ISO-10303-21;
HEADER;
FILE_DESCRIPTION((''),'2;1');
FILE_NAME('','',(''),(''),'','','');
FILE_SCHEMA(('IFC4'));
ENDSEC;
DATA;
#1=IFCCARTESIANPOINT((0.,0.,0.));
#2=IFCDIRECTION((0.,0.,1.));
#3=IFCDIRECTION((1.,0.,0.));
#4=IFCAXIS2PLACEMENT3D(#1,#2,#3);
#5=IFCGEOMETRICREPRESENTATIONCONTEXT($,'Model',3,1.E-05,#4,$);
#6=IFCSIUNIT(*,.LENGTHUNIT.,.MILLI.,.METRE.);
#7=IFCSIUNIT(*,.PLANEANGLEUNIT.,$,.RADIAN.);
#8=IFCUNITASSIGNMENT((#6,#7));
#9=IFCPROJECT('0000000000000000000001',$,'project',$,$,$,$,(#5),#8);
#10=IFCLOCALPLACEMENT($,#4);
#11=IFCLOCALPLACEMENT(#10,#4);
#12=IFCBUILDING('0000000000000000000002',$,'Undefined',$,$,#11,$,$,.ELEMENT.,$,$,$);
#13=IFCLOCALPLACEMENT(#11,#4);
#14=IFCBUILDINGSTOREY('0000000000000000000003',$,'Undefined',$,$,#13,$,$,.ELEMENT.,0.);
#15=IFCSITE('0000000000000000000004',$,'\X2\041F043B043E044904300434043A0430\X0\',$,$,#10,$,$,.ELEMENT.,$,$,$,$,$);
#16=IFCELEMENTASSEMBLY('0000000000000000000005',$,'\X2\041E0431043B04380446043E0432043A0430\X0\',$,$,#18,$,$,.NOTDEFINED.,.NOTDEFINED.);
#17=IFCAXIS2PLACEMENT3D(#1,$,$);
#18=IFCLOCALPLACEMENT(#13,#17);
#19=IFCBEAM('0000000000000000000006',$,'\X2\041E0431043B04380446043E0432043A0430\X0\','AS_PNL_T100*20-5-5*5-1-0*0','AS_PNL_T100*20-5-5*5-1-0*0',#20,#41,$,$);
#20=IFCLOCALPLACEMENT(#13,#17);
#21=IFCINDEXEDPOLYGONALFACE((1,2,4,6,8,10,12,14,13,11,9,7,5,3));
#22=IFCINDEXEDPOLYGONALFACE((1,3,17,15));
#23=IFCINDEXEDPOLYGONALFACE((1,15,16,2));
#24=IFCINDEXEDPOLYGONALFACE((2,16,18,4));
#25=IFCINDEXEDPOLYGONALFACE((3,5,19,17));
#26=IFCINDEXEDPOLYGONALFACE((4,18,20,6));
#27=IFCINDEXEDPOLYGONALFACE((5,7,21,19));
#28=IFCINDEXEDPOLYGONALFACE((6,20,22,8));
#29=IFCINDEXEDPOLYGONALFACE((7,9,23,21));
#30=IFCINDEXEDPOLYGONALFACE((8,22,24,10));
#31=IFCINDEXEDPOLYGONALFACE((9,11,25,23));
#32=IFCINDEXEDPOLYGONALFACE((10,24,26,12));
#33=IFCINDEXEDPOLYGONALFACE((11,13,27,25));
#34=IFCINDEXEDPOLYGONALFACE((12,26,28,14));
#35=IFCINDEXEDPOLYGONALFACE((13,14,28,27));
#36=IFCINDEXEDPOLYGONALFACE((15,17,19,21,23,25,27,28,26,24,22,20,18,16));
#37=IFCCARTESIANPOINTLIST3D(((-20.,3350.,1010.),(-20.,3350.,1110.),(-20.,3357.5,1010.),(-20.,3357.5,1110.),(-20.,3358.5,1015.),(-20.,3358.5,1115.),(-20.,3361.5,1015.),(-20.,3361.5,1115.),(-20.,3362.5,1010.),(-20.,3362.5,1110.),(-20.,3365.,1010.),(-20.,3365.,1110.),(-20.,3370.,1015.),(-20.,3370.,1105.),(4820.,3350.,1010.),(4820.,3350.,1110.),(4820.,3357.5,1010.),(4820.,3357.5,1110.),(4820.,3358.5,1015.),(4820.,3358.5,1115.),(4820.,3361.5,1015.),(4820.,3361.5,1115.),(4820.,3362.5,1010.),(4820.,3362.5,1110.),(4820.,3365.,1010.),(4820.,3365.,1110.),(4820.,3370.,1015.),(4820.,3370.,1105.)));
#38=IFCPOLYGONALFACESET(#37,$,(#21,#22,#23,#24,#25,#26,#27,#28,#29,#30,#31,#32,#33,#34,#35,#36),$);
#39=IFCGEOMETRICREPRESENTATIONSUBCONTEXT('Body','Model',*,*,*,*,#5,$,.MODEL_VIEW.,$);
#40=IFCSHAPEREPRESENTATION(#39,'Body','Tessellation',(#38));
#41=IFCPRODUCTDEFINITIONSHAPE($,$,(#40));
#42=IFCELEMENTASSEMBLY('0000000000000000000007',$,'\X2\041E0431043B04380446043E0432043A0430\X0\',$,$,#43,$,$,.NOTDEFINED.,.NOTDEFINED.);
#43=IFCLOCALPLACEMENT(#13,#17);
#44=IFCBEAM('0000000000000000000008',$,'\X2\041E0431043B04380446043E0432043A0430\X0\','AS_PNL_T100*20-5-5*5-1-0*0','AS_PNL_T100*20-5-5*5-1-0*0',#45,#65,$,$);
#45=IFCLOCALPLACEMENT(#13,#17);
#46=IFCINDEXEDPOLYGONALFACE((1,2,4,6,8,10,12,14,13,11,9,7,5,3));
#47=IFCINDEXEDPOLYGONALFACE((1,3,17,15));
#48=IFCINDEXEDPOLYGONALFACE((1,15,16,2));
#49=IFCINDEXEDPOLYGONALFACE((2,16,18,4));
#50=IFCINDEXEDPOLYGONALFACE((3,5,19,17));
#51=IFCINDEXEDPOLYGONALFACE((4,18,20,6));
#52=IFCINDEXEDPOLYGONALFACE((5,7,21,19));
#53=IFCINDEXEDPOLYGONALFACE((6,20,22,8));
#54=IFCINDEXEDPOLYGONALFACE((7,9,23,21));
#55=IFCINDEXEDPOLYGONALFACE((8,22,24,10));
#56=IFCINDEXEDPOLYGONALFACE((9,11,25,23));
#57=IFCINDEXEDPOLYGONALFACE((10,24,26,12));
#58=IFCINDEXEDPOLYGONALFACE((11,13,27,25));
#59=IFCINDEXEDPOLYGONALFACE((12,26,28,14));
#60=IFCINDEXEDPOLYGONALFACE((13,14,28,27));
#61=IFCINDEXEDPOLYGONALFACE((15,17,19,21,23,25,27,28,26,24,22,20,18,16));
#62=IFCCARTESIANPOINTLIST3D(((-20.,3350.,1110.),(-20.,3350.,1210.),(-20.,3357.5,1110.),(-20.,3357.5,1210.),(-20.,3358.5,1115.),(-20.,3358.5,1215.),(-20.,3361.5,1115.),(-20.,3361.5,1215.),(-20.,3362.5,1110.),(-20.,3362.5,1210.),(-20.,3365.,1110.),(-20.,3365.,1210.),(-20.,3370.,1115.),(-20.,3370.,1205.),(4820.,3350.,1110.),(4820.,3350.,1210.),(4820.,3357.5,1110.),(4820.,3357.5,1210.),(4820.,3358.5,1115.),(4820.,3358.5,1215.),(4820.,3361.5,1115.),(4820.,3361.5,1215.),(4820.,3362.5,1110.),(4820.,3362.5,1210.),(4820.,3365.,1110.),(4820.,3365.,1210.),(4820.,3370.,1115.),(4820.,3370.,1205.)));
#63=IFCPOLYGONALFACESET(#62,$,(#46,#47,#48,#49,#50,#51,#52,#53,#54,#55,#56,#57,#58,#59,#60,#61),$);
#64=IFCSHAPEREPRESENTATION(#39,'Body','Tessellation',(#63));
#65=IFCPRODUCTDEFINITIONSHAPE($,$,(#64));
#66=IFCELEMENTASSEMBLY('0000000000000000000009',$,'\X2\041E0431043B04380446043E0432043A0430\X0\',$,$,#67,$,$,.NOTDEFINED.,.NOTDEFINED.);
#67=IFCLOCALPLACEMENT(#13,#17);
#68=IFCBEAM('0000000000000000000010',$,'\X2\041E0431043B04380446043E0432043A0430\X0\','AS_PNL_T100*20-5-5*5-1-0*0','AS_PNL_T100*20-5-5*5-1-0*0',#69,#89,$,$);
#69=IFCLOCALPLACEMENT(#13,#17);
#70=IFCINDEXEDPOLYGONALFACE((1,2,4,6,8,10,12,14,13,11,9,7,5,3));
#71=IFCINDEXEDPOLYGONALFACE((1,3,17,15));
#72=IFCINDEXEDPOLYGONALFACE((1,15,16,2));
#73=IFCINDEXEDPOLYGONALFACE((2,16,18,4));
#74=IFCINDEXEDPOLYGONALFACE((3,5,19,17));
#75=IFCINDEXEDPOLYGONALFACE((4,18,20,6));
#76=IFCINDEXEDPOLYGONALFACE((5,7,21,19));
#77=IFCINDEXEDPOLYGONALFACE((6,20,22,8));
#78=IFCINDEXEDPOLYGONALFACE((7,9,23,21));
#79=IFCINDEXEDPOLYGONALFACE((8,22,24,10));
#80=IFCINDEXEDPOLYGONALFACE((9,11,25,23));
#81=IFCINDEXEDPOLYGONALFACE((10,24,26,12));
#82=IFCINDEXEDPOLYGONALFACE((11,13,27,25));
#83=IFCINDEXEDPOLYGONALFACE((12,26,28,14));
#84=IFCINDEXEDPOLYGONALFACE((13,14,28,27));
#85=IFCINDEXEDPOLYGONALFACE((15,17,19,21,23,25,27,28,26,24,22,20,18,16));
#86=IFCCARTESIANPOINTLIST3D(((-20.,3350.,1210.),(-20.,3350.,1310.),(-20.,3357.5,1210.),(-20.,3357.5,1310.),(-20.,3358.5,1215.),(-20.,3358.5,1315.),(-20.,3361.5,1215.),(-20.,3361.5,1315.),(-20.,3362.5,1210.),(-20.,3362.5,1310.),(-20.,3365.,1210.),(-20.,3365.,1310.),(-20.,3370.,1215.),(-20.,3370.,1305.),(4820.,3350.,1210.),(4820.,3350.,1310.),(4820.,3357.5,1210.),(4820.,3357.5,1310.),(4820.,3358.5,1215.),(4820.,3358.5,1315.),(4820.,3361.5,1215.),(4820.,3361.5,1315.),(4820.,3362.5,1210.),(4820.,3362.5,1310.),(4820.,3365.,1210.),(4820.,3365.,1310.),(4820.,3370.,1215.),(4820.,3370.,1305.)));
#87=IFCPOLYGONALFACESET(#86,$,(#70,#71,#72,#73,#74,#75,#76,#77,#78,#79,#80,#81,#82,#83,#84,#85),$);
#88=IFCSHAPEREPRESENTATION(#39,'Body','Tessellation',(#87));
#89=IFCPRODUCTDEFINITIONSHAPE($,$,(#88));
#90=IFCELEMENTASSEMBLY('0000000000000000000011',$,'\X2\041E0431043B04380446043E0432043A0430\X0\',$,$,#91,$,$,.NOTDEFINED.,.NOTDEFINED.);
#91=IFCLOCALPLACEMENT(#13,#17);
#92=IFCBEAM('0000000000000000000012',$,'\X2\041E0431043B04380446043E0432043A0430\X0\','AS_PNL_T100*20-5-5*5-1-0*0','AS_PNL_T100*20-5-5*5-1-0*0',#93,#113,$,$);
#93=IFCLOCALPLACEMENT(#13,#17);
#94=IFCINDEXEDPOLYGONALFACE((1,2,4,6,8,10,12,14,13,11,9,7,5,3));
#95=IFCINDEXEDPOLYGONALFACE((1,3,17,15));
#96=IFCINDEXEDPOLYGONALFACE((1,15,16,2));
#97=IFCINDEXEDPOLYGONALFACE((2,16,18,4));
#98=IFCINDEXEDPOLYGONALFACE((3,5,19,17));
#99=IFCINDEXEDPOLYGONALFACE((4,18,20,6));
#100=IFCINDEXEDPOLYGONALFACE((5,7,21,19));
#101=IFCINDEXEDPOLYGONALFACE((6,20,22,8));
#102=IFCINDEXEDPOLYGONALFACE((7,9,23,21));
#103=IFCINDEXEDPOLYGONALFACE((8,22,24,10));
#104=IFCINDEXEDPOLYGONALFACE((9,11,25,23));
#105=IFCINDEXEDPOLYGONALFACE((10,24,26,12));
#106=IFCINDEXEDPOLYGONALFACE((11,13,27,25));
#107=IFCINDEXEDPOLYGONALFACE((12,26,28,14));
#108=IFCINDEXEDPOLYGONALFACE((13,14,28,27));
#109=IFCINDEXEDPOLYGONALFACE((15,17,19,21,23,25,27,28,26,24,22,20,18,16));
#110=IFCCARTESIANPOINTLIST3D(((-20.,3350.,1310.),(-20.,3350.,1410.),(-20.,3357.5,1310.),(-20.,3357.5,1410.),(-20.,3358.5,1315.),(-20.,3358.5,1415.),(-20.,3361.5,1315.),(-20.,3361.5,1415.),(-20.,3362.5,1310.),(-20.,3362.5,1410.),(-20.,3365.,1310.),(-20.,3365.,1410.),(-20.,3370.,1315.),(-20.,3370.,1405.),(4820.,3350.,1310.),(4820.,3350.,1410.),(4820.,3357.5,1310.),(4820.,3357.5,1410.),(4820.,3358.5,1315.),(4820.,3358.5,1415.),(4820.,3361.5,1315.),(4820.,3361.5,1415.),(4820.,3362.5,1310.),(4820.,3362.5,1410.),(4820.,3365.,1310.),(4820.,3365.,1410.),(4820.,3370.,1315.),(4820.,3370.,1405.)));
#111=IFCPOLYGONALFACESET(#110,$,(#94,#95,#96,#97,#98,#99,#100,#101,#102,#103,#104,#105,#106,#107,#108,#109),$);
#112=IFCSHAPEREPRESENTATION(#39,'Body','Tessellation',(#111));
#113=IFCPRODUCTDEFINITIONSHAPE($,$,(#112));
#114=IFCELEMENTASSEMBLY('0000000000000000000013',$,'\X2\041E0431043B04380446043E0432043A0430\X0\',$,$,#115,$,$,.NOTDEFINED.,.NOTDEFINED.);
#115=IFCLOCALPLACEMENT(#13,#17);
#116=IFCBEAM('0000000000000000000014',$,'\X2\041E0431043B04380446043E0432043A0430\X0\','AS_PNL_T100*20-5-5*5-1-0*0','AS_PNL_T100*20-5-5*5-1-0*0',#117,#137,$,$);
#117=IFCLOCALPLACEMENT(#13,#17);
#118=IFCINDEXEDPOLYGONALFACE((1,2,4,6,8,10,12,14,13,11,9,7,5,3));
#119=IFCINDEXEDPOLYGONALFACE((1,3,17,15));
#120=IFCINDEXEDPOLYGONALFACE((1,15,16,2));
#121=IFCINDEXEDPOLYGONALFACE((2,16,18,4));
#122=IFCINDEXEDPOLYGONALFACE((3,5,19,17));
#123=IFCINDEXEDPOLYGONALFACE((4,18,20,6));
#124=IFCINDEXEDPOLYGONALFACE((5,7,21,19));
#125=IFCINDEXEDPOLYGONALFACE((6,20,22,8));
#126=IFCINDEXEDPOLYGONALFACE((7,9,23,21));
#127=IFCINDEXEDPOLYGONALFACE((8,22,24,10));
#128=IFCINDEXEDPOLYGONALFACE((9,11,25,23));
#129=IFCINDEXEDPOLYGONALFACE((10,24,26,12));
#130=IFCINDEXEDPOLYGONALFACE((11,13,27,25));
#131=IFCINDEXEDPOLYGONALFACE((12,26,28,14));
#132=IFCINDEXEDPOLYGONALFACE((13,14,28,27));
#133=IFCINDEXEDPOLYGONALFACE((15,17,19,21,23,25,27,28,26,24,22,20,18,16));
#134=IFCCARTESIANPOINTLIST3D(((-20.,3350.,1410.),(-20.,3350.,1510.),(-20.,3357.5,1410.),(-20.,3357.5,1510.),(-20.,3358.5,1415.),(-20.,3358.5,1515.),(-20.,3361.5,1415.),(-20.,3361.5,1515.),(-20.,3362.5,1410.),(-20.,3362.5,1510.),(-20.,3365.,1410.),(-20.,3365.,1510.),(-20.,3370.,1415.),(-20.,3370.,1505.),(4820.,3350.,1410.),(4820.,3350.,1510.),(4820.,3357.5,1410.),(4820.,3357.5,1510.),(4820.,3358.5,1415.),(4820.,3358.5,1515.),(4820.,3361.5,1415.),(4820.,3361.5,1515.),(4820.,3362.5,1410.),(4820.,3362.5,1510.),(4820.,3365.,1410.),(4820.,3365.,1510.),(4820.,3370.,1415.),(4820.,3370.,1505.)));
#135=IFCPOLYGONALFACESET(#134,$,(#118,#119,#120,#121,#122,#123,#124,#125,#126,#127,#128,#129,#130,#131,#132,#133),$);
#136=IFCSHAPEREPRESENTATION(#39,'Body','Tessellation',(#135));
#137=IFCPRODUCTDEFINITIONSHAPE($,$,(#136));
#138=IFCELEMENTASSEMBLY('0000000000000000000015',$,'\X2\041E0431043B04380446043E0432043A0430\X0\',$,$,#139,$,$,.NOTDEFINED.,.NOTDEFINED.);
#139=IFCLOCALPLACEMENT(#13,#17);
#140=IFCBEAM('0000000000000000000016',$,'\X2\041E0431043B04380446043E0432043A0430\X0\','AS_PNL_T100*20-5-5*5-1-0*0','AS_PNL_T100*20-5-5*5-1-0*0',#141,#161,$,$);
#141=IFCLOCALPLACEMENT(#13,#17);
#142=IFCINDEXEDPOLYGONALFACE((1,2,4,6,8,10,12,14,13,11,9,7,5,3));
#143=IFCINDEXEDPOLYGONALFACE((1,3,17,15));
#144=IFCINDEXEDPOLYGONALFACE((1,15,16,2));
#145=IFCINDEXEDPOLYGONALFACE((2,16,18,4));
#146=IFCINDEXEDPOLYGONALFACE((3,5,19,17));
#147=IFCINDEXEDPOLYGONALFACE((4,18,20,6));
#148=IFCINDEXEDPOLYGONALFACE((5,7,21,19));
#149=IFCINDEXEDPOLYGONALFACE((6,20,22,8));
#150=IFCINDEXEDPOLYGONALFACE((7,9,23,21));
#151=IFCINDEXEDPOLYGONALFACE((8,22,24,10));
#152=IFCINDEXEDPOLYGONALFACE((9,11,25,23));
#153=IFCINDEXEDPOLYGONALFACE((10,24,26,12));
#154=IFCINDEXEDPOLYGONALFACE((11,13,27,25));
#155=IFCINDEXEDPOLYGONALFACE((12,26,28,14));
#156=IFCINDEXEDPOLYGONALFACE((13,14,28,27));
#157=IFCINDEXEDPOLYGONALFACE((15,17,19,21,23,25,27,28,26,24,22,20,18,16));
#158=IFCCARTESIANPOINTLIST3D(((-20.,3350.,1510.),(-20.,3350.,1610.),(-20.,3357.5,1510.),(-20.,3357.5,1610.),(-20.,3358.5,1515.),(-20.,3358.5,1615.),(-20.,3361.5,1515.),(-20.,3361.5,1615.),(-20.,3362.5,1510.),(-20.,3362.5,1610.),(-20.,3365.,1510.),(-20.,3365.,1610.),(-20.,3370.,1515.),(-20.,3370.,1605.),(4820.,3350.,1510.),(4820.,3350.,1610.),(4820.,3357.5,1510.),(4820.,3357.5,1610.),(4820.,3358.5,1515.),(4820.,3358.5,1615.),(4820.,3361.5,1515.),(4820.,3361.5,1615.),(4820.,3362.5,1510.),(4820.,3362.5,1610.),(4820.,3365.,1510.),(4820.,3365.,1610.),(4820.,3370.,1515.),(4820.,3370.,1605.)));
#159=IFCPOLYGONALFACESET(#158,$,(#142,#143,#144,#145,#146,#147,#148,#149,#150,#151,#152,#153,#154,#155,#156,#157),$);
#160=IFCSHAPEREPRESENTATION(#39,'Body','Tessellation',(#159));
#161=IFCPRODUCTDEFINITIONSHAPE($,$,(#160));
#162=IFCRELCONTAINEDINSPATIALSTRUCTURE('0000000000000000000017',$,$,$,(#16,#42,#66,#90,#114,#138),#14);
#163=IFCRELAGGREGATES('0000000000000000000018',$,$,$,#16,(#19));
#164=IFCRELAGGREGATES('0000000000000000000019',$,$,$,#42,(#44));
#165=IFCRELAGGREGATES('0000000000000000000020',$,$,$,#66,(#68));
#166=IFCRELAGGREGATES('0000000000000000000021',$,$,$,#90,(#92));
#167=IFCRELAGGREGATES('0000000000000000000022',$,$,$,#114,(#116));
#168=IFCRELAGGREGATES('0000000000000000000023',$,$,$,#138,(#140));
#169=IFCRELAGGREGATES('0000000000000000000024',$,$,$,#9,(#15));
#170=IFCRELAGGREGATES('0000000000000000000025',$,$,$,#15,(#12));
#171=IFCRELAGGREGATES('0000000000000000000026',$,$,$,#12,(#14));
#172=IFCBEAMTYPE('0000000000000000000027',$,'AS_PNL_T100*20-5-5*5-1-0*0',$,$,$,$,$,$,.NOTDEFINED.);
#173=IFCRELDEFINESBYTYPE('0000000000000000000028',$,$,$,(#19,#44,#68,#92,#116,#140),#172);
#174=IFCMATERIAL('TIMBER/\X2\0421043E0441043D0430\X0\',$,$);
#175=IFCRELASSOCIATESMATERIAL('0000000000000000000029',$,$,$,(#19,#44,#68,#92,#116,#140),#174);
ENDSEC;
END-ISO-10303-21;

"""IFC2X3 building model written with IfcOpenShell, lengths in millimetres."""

from ifc_helpers import new_model, si_unit, frame, origin_with_axes, place, context, subcontext, project, spatial, polyline, outline, extrude, material, type_object, element, aggregate, save


model = new_model("IFC2X3")

# Units and contexts
model_context = context("Model", 3, precision=1e-05, world=origin_with_axes())
body_context = subcontext(model_context, "Body", "Model", "MODEL_VIEW")
ifc_project = project(units=[si_unit("LENGTHUNIT", "METRE", prefix="MILLI"), si_unit("PLANEANGLEUNIT", "RADIAN")], contexts=[model_context])

# Site, building, storey
site_placement = place(None, origin_with_axes())
site = spatial("IfcSite", under=ifc_project, at=site_placement, Name="Площадка", CompositionType="ELEMENT")
building_placement = place(site_placement, origin_with_axes())
building = spatial("IfcBuilding", under=site, at=building_placement, Name="Undefined", CompositionType="ELEMENT")
storey_placement = place(building_placement, origin_with_axes())
storey = spatial("IfcBuildingStorey", under=building, at=storey_placement, Name="Undefined", CompositionType="ELEMENT", Elevation=0.0)

# Shared definitions
ifc_material = material(Name="TIMBER/Сосна")

# Element assemblies, beams
assembly_1_placement = place(storey_placement, origin_with_axes())
assembly_1 = element("IfcElementAssembly", 1, at=assembly_1_placement, inside=storey, Name="Облицовка", AssemblyPlace="NOTDEFINED", PredefinedType="NOTDEFINED")
beam_type_1 = type_object("IfcBeamType", Name="AS_PNL_T100*20-5-5*5-1-0*0", PredefinedType="NOTDEFINED")
beam_1_placement = place(assembly_1_placement, frame((4820.0, 3360.0, 1060.0), z_axis=(0.0, 0.0, 1.0), x_axis=(-1.0, 0.0, 0.0)))
beam_1 = element("IfcBeam", 2, at=beam_1_placement, type_object=beam_type_1, material=ifc_material, Name="Облицовка", Description="AS_PNL_T100*20-5-5*5-1-0*0", ObjectType="AS_PNL_T100*20-5-5*5-1-0*0", context=body_context, shape_type="SweptSolid", body=[
    extrude(outline(polyline([(-2.5, -50.0), (-10.0, -50.0), (-10.0, 50.0), (-2.5, 50.0), (-1.5, 55.0), (1.5, 55.0), (2.5, 50.0), (5.0, 50.0), (10.0, 45.0), (10.0, -45.0), (5.0, -50.0), (2.5, -50.0), (1.5, -45.0), (-1.5, -45.0), (-2.5, -50.0)])), frame((4840.0, 0.0, 0.0), z_axis=(-1.0, 0.0, 0.0), x_axis=(0.0, -1.0, 0.0)), (0.0, 0.0, 1.0), 4840.0),
])
aggregate(assembly_1, [beam_1])
assembly_2_placement = place(storey_placement, origin_with_axes())
assembly_2 = element("IfcElementAssembly", 3, at=assembly_2_placement, inside=storey, Name="Облицовка", AssemblyPlace="NOTDEFINED", PredefinedType="NOTDEFINED")
beam_2_placement = place(assembly_2_placement, frame((4820.0, 3360.0, 1160.0), z_axis=(0.0, 0.0, 1.0), x_axis=(-1.0, 0.0, 0.0)))
beam_2 = element("IfcBeam", 4, at=beam_2_placement, type_object=beam_type_1, material=ifc_material, Name="Облицовка", Description="AS_PNL_T100*20-5-5*5-1-0*0", ObjectType="AS_PNL_T100*20-5-5*5-1-0*0", context=body_context, shape_type="SweptSolid", body=[
    extrude(outline(polyline([(-2.5, -50.0), (-10.0, -50.0), (-10.0, 50.0), (-2.5, 50.0), (-1.5, 55.0), (1.5, 55.0), (2.5, 50.0), (5.0, 50.0), (10.0, 45.0), (10.0, -45.0), (5.0, -50.0), (2.5, -50.0), (1.5, -45.0), (-1.5, -45.0), (-2.5, -50.0)])), frame((4840.0, 0.0, 0.0), z_axis=(-1.0, 0.0, 0.0), x_axis=(0.0, -1.0, 0.0)), (0.0, 0.0, 1.0), 4840.0),
])
aggregate(assembly_2, [beam_2])
assembly_3_placement = place(storey_placement, origin_with_axes())
assembly_3 = element("IfcElementAssembly", 5, at=assembly_3_placement, inside=storey, Name="Облицовка", AssemblyPlace="NOTDEFINED", PredefinedType="NOTDEFINED")
beam_3_placement = place(assembly_3_placement, frame((4820.0, 3360.0, 1260.0), z_axis=(0.0, 0.0, 1.0), x_axis=(-1.0, 0.0, 0.0)))
beam_3 = element("IfcBeam", 6, at=beam_3_placement, type_object=beam_type_1, material=ifc_material, Name="Облицовка", Description="AS_PNL_T100*20-5-5*5-1-0*0", ObjectType="AS_PNL_T100*20-5-5*5-1-0*0", context=body_context, shape_type="SweptSolid", body=[
    extrude(outline(polyline([(-2.5, -50.0), (-10.0, -50.0), (-10.0, 50.0), (-2.5, 50.0), (-1.5, 55.0), (1.5, 55.0), (2.5, 50.0), (5.0, 50.0), (10.0, 45.0), (10.0, -45.0), (5.0, -50.0), (2.5, -50.0), (1.5, -45.0), (-1.5, -45.0), (-2.5, -50.0)])), frame((4840.0, 0.0, 0.0), z_axis=(-1.0, 0.0, 0.0), x_axis=(0.0, -1.0, 0.0)), (0.0, 0.0, 1.0), 4840.0),
])
aggregate(assembly_3, [beam_3])
assembly_4_placement = place(storey_placement, origin_with_axes())
assembly_4 = element("IfcElementAssembly", 7, at=assembly_4_placement, inside=storey, Name="Облицовка", AssemblyPlace="NOTDEFINED", PredefinedType="NOTDEFINED")
beam_4_placement = place(assembly_4_placement, frame((4820.0, 3360.0, 1360.0), z_axis=(0.0, 0.0, 1.0), x_axis=(-1.0, 0.0, 0.0)))
beam_4 = element("IfcBeam", 8, at=beam_4_placement, type_object=beam_type_1, material=ifc_material, Name="Облицовка", Description="AS_PNL_T100*20-5-5*5-1-0*0", ObjectType="AS_PNL_T100*20-5-5*5-1-0*0", context=body_context, shape_type="SweptSolid", body=[
    extrude(outline(polyline([(-2.5, -50.0), (-10.0, -50.0), (-10.0, 50.0), (-2.5, 50.0), (-1.5, 55.0), (1.5, 55.0), (2.5, 50.0), (5.0, 50.0), (10.0, 45.0), (10.0, -45.0), (5.0, -50.0), (2.5, -50.0), (1.5, -45.0), (-1.5, -45.0), (-2.5, -50.0)])), frame((4840.0, 0.0, 0.0), z_axis=(-1.0, 0.0, 0.0), x_axis=(0.0, -1.0, 0.0)), (0.0, 0.0, 1.0), 4840.0),
])
aggregate(assembly_4, [beam_4])
assembly_5_placement = place(storey_placement, origin_with_axes())
assembly_5 = element("IfcElementAssembly", 9, at=assembly_5_placement, inside=storey, Name="Облицовка", AssemblyPlace="NOTDEFINED", PredefinedType="NOTDEFINED")
beam_5_placement = place(assembly_5_placement, frame((4820.0, 3360.0, 1460.0), z_axis=(0.0, 0.0, 1.0), x_axis=(-1.0, 0.0, 0.0)))
beam_5 = element("IfcBeam", 10, at=beam_5_placement, type_object=beam_type_1, material=ifc_material, Name="Облицовка", Description="AS_PNL_T100*20-5-5*5-1-0*0", ObjectType="AS_PNL_T100*20-5-5*5-1-0*0", context=body_context, shape_type="SweptSolid", body=[
    extrude(outline(polyline([(-2.5, -50.0), (-10.0, -50.0), (-10.0, 50.0), (-2.5, 50.0), (-1.5, 55.0), (1.5, 55.0), (2.5, 50.0), (5.0, 50.0), (10.0, 45.0), (10.0, -45.0), (5.0, -50.0), (2.5, -50.0), (1.5, -45.0), (-1.5, -45.0), (-2.5, -50.0)])), frame((4840.0, 0.0, 0.0), z_axis=(-1.0, 0.0, 0.0), x_axis=(0.0, -1.0, 0.0)), (0.0, 0.0, 1.0), 4840.0),
])
aggregate(assembly_5, [beam_5])
assembly_6_placement = place(storey_placement, origin_with_axes())
assembly_6 = element("IfcElementAssembly", 11, at=assembly_6_placement, inside=storey, Name="Облицовка", AssemblyPlace="NOTDEFINED", PredefinedType="NOTDEFINED")
beam_6_placement = place(assembly_6_placement, frame((4820.0, 3360.0, 1560.0), z_axis=(0.0, 0.0, 1.0), x_axis=(-1.0, 0.0, 0.0)))
beam_6 = element("IfcBeam", 12, at=beam_6_placement, type_object=beam_type_1, material=ifc_material, Name="Облицовка", Description="AS_PNL_T100*20-5-5*5-1-0*0", ObjectType="AS_PNL_T100*20-5-5*5-1-0*0", context=body_context, shape_type="SweptSolid", body=[
    extrude(outline(polyline([(-2.5, -50.0), (-10.0, -50.0), (-10.0, 50.0), (-2.5, 50.0), (-1.5, 55.0), (1.5, 55.0), (2.5, 50.0), (5.0, 50.0), (10.0, 45.0), (10.0, -45.0), (5.0, -50.0), (2.5, -50.0), (1.5, -45.0), (-1.5, -45.0), (-2.5, -50.0)])), frame((4840.0, 0.0, 0.0), z_axis=(-1.0, 0.0, 0.0), x_axis=(0.0, -1.0, 0.0)), (0.0, 0.0, 1.0), 4840.0),
])
aggregate(assembly_6, [beam_6])

save(model, "model.ifc")
